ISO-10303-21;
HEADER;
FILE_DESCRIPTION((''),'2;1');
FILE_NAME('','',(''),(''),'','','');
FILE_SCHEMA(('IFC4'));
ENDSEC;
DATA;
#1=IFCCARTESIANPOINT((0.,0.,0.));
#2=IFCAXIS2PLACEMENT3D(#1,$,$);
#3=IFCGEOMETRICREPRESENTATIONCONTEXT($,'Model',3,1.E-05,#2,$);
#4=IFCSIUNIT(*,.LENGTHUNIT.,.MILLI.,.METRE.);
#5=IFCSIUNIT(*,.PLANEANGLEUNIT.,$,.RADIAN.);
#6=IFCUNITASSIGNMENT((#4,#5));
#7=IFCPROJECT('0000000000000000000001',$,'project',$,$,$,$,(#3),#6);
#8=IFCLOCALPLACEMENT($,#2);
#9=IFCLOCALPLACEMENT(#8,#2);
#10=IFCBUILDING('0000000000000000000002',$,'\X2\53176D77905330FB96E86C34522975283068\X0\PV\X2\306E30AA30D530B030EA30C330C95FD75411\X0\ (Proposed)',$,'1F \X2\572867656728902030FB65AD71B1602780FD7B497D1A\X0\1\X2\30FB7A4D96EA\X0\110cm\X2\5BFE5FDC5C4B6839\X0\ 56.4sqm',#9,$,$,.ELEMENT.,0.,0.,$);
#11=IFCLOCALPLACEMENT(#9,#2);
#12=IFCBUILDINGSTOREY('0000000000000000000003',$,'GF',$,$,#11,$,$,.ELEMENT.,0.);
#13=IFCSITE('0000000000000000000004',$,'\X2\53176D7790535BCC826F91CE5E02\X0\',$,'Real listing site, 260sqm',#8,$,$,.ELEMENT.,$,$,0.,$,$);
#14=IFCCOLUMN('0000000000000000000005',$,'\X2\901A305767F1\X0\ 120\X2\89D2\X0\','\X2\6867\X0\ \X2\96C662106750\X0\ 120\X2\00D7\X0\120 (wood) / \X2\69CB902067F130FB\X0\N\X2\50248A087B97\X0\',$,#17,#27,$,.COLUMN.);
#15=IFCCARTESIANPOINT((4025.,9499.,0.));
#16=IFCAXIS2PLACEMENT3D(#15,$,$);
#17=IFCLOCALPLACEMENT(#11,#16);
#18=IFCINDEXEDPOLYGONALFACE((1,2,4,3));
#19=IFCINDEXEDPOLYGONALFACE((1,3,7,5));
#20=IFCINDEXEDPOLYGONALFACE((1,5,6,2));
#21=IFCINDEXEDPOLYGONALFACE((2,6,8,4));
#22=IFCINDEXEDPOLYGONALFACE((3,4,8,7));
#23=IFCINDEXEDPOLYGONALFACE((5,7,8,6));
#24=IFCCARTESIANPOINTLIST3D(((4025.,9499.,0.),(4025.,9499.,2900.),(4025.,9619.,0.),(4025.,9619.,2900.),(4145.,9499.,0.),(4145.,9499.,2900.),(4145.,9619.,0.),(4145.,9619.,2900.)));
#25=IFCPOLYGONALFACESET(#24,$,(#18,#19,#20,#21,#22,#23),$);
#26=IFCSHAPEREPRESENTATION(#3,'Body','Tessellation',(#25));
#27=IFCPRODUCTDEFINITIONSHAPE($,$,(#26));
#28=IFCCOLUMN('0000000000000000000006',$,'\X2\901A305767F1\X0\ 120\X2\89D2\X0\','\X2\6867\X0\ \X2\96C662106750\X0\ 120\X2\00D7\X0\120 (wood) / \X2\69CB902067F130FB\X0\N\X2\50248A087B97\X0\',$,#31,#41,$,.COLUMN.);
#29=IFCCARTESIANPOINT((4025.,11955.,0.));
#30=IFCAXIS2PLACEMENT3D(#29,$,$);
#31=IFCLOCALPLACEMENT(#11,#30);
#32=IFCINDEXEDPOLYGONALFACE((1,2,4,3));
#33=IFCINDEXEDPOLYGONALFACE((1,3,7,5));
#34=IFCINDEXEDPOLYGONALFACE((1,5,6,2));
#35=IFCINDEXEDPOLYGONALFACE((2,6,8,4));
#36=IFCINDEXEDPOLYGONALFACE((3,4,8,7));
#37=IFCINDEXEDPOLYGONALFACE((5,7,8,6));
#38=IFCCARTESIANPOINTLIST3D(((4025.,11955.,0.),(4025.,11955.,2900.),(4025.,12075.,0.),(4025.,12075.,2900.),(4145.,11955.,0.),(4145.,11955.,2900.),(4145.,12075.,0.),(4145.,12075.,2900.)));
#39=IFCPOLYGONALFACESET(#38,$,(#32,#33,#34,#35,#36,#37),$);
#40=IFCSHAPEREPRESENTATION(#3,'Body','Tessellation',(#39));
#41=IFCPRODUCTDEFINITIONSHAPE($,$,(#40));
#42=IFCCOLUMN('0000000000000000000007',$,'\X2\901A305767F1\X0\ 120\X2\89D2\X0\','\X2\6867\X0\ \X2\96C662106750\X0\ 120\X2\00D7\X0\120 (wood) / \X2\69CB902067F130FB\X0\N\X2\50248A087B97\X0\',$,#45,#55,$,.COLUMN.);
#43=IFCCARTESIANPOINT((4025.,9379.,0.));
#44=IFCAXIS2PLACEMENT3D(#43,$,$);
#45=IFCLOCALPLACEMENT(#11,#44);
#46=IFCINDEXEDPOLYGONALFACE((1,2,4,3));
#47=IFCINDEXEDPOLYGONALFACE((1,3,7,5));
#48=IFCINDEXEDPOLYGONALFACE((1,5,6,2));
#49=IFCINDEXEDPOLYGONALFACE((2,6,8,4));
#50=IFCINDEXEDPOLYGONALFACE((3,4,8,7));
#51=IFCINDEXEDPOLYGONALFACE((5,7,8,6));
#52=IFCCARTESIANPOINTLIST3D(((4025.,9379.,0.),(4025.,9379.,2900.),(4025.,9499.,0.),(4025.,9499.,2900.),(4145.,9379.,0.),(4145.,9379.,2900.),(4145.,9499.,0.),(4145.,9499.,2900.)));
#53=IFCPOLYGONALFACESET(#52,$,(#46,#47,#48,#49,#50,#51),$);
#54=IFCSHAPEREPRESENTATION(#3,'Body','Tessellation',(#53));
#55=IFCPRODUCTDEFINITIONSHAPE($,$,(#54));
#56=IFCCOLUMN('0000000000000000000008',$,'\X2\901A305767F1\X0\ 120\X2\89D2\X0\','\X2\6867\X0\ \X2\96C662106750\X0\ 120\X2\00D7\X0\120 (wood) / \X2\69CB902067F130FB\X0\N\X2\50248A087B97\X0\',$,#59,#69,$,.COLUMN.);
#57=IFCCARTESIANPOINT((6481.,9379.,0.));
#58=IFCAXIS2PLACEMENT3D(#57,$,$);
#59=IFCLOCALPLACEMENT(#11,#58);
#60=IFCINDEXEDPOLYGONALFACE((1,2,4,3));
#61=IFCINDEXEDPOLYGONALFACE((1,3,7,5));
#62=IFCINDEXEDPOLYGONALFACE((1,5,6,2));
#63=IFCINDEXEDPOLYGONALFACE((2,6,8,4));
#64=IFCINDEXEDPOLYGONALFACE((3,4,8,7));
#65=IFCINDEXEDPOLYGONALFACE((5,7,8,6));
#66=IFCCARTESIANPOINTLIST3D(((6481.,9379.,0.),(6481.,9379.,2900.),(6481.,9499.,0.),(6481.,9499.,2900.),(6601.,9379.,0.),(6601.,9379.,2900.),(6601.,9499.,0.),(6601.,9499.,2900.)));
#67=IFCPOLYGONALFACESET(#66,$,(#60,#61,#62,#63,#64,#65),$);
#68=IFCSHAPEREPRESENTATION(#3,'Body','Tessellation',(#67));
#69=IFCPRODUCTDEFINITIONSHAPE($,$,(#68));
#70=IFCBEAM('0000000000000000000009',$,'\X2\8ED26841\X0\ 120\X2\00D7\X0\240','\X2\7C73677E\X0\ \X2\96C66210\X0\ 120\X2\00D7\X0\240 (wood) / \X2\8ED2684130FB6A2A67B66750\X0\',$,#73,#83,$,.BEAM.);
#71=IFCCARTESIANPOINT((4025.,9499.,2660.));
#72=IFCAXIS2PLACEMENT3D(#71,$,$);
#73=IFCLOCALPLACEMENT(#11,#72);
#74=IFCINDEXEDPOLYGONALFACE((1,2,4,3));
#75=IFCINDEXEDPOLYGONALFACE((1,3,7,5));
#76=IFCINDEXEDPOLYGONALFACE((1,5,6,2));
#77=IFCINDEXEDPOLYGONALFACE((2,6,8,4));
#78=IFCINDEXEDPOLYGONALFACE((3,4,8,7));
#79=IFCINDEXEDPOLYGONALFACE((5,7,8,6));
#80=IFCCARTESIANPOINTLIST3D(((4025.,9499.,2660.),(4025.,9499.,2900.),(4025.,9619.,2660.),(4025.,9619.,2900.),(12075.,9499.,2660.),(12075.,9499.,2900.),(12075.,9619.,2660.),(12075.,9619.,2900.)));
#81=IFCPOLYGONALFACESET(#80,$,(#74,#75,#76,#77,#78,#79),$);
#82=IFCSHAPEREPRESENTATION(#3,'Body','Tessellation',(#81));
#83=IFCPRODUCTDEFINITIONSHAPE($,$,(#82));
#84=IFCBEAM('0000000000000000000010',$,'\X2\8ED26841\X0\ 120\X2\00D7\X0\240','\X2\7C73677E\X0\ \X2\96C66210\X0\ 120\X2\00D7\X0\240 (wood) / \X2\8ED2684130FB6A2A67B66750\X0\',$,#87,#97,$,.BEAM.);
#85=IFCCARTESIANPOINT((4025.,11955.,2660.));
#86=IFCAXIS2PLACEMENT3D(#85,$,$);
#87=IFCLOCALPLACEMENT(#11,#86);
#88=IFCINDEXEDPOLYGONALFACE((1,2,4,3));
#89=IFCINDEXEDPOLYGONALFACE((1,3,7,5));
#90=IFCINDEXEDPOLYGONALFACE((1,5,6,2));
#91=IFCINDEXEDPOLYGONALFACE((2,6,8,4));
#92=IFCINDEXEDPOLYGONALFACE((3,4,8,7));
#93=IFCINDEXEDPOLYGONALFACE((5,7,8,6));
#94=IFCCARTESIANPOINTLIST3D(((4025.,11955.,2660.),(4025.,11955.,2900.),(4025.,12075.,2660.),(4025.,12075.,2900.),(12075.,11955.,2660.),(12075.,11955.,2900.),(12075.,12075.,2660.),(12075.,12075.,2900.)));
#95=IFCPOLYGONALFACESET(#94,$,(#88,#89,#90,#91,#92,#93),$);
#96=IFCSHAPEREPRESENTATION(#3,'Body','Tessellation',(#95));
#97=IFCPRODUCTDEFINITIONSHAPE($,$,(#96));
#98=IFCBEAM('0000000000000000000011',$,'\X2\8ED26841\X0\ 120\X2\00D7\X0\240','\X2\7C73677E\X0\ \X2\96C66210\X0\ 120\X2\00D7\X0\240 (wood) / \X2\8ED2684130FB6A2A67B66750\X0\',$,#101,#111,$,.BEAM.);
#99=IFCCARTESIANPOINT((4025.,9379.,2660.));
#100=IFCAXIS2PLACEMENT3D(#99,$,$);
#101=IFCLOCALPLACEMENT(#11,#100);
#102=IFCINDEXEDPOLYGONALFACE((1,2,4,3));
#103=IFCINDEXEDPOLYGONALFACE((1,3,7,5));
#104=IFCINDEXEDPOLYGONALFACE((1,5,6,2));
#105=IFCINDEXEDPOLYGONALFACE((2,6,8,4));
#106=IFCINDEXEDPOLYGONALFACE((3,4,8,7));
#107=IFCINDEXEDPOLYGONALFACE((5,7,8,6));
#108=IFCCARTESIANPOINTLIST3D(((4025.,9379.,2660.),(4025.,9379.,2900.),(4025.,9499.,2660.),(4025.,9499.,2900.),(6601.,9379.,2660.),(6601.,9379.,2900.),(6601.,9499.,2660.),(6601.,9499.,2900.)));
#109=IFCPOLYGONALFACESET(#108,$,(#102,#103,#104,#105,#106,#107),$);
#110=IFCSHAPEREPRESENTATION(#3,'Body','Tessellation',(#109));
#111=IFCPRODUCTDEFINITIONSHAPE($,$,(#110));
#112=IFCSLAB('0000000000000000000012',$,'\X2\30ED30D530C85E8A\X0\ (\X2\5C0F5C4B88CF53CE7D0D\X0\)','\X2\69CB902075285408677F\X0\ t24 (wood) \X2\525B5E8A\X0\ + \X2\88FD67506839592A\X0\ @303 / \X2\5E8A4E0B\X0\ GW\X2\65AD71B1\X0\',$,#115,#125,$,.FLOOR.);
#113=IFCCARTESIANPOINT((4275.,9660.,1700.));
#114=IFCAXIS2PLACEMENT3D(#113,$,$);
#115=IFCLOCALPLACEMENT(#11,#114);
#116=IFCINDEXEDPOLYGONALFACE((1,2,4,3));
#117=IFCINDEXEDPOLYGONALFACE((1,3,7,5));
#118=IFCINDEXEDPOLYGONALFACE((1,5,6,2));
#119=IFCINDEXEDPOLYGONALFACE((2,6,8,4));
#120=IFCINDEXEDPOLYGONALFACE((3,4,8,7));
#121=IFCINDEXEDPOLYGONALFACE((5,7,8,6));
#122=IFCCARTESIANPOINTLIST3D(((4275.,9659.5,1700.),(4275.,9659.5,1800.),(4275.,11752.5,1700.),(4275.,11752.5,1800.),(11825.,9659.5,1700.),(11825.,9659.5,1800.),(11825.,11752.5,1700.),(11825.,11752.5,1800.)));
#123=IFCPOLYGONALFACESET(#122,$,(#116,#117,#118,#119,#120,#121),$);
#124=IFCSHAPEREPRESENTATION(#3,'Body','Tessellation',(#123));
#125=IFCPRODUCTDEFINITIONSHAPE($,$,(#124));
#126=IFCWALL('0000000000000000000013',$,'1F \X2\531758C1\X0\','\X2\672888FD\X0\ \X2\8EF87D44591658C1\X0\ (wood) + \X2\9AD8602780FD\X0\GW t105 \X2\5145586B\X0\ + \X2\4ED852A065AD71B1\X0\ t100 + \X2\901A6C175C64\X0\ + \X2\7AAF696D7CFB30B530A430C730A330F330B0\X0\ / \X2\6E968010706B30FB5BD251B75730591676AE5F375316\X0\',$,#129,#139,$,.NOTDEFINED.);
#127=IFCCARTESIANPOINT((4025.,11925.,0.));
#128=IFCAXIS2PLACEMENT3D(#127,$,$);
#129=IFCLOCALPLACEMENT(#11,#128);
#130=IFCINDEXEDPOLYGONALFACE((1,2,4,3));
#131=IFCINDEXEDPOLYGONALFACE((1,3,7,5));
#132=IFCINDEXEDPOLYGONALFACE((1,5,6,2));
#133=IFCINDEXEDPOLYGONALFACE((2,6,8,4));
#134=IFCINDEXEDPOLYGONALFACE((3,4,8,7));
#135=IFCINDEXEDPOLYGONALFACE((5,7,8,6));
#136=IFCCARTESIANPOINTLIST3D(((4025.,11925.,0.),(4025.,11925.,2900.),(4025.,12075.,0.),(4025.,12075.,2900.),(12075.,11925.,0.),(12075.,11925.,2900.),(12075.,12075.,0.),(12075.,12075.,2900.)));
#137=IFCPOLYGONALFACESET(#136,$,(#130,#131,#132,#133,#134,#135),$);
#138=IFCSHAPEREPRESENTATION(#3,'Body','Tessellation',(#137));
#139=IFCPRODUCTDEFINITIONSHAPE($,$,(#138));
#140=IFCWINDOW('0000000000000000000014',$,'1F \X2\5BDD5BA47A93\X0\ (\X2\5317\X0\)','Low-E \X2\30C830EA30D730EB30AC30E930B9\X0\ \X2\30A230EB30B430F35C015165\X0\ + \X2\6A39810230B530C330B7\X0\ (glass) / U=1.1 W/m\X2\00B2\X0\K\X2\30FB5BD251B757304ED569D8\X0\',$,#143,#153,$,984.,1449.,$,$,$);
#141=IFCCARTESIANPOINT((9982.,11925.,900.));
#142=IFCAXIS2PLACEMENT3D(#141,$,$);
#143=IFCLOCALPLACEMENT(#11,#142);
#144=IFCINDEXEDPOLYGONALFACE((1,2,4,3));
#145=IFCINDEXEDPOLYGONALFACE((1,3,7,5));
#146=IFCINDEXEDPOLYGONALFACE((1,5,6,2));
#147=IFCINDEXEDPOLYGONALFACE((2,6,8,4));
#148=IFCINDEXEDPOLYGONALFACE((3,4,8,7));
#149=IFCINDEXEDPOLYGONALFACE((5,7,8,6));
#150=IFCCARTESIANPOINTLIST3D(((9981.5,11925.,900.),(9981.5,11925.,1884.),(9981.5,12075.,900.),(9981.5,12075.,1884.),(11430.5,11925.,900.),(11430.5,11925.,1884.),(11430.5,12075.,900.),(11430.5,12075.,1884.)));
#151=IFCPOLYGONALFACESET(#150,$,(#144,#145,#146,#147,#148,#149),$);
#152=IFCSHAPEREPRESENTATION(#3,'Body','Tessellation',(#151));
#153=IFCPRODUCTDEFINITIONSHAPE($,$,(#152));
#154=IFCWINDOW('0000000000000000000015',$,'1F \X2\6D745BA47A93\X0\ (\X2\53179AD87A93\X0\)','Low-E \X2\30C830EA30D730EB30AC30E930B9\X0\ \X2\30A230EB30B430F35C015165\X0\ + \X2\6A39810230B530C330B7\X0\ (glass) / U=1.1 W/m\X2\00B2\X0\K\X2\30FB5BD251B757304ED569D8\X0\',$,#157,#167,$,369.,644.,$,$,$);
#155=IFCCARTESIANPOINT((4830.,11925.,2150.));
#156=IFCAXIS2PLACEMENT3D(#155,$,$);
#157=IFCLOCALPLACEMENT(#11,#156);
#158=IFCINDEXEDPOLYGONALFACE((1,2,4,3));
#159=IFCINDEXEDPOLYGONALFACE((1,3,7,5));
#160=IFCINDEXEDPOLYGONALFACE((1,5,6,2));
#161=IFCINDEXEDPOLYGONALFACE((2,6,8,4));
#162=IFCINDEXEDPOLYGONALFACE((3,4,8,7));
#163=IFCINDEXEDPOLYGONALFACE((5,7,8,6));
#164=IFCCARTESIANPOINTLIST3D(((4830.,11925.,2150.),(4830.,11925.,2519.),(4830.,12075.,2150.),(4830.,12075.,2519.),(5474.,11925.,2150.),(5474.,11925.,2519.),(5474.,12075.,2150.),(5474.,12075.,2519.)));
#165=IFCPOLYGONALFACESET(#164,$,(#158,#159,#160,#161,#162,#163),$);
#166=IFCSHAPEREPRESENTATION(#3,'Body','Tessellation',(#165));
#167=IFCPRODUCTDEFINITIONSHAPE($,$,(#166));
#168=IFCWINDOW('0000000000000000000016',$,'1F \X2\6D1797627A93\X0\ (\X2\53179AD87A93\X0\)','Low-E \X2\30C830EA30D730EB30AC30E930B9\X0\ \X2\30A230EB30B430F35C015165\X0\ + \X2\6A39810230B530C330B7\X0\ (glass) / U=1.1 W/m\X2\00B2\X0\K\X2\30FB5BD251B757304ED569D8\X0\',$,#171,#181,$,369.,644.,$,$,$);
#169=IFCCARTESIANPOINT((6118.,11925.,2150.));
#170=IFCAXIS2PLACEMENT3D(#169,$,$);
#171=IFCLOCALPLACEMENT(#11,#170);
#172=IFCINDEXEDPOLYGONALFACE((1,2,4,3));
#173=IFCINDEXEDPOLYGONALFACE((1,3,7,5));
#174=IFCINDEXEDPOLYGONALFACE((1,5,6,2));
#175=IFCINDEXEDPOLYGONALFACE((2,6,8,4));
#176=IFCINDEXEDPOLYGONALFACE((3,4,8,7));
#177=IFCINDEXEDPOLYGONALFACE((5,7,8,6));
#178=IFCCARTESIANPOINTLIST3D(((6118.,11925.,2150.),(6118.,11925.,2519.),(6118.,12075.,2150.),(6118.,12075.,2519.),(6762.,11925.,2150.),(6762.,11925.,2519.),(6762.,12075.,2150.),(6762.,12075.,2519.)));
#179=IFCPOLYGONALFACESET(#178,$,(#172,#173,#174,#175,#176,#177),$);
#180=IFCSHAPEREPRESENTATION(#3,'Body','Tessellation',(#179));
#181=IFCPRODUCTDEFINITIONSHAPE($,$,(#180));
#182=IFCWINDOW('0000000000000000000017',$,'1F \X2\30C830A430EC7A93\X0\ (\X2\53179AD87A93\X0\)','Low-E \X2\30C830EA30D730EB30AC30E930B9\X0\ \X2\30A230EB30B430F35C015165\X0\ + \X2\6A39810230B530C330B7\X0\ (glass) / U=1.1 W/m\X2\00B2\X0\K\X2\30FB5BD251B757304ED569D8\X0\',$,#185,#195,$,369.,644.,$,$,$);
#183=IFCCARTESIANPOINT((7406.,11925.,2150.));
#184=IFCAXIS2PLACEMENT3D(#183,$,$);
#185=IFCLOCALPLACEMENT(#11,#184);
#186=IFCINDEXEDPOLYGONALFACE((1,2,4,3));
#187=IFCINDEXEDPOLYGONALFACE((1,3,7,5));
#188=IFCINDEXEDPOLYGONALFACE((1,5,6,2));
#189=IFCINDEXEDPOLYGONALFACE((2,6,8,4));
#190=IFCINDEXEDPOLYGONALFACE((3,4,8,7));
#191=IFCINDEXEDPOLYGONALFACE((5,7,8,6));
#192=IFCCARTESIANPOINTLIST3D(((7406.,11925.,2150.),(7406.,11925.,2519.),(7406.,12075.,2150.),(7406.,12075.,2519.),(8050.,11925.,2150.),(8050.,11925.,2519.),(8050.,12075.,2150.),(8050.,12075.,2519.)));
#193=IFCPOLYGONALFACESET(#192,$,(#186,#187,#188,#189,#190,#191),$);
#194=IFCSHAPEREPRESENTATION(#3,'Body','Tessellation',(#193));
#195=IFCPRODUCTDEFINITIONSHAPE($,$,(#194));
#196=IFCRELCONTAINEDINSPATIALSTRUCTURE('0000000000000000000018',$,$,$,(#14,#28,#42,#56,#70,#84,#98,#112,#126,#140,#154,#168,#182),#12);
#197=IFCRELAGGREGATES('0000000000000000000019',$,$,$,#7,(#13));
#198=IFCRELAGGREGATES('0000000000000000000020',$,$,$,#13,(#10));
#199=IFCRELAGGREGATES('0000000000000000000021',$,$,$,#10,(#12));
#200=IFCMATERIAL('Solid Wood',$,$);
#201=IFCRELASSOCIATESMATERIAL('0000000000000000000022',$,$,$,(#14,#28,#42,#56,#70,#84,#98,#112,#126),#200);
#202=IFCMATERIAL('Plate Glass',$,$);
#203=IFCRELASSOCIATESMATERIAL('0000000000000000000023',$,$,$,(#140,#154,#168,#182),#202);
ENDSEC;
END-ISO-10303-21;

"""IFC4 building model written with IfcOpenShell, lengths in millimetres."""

from ifc_helpers import new_model, si_unit, frame, frame_2d, origin, place, context, project, spatial, rectangle, extrude, material, element, fill, save


model = new_model("IFC4")

# Units and contexts
model_context = context("Model", 3, precision=1e-05, world=origin())
ifc_project = project(units=[si_unit("LENGTHUNIT", "METRE", prefix="MILLI"), si_unit("PLANEANGLEUNIT", "RADIAN")], contexts=[model_context])

# Site, building, storey
site_placement = place(None, origin())
site = spatial("IfcSite", under=ifc_project, at=site_placement, Name="北海道富良野市", ObjectType="Real listing site, 260sqm", CompositionType="ELEMENT", RefElevation=0.0)
building_placement = place(site_placement, origin())
building = spatial("IfcBuilding", under=site, at=building_placement, Name="北海道・雨水利用とPVのオフグリッド志向 (Proposed)", ObjectType="1F 在来木造・断熱性能等級1・積雪110cm対応屋根 56.4sqm", CompositionType="ELEMENT", ElevationOfRefHeight=0.0, ElevationOfTerrain=0.0)
storey_placement = place(building_placement, origin())
storey = spatial("IfcBuildingStorey", under=building, at=storey_placement, Name="GF", CompositionType="ELEMENT", Elevation=0.0)

# Columns
ifc_material_1 = material(Name="Solid Wood")
column_1_placement = place(storey_placement, frame((4025.0, 9499.0, 0.0)))
element("IfcColumn", 1, at=column_1_placement, inside=storey, material=ifc_material_1, Name="通し柱 120角", Description="桧 集成材 120×120 (wood) / 構造柱・N値計算", PredefinedType="COLUMN", context=model_context, shape_type="SweptSolid", body=[
    extrude(rectangle(XDim=120.0, YDim=120.0, at=frame_2d((60.0, 60.0))), frame((4025.0, 9499.0, 0.0)), (0.0, 0.0, 1.0), 2900.0),
])
column_2_placement = place(storey_placement, frame((4025.0, 11955.0, 0.0)))
element("IfcColumn", 2, at=column_2_placement, inside=storey, material=ifc_material_1, Name="通し柱 120角", Description="桧 集成材 120×120 (wood) / 構造柱・N値計算", PredefinedType="COLUMN", context=model_context, shape_type="SweptSolid", body=[
    extrude(rectangle(XDim=120.0, YDim=120.0, at=frame_2d((60.0, 60.0))), frame((4025.0, 11955.0, 0.0)), (0.0, 0.0, 1.0), 2900.0),
])
column_3_placement = place(storey_placement, frame((4025.0, 9379.0, 0.0)))
element("IfcColumn", 3, at=column_3_placement, inside=storey, material=ifc_material_1, Name="通し柱 120角", Description="桧 集成材 120×120 (wood) / 構造柱・N値計算", PredefinedType="COLUMN", context=model_context, shape_type="SweptSolid", body=[
    extrude(rectangle(XDim=120.0, YDim=120.0, at=frame_2d((60.0, 60.0))), frame((4025.0, 9379.0, 0.0)), (0.0, 0.0, 1.0), 2900.0),
])
column_4_placement = place(storey_placement, frame((6481.0, 9379.0, 0.0)))
element("IfcColumn", 4, at=column_4_placement, inside=storey, material=ifc_material_1, Name="通し柱 120角", Description="桧 集成材 120×120 (wood) / 構造柱・N値計算", PredefinedType="COLUMN", context=model_context, shape_type="SweptSolid", body=[
    extrude(rectangle(XDim=120.0, YDim=120.0, at=frame_2d((60.0, 60.0))), frame((6481.0, 9379.0, 0.0)), (0.0, 0.0, 1.0), 2900.0),
])

# Beams
beam_1_placement = place(storey_placement, frame((4025.0, 9499.0, 2660.0)))
element("IfcBeam", 5, at=beam_1_placement, inside=storey, material=ifc_material_1, Name="軒桁 120×240", Description="米松 集成 120×240 (wood) / 軒桁・横架材", PredefinedType="BEAM", context=model_context, shape_type="SweptSolid", body=[
    extrude(rectangle(XDim=8050.0, YDim=120.0, at=frame_2d((4025.0, 60.0))), frame((4025.0, 9499.0, 2660.0)), (0.0, 0.0, 1.0), 240.0),
])
beam_2_placement = place(storey_placement, frame((4025.0, 11955.0, 2660.0)))
element("IfcBeam", 6, at=beam_2_placement, inside=storey, material=ifc_material_1, Name="軒桁 120×240", Description="米松 集成 120×240 (wood) / 軒桁・横架材", PredefinedType="BEAM", context=model_context, shape_type="SweptSolid", body=[
    extrude(rectangle(XDim=8050.0, YDim=120.0, at=frame_2d((4025.0, 60.0))), frame((4025.0, 11955.0, 2660.0)), (0.0, 0.0, 1.0), 240.0),
])
beam_3_placement = place(storey_placement, frame((4025.0, 9379.0, 2660.0)))
element("IfcBeam", 7, at=beam_3_placement, inside=storey, material=ifc_material_1, Name="軒桁 120×240", Description="米松 集成 120×240 (wood) / 軒桁・横架材", PredefinedType="BEAM", context=model_context, shape_type="SweptSolid", body=[
    extrude(rectangle(XDim=2576.0, YDim=120.0, at=frame_2d((1288.0, 60.0))), frame((4025.0, 9379.0, 2660.0)), (0.0, 0.0, 1.0), 240.0),
])

# Slab
slab_1_placement = place(storey_placement, frame((4275.0, 9660.0, 1700.0)))
element("IfcSlab", 8, at=slab_1_placement, inside=storey, material=ifc_material_1, Name="ロフト床 (小屋裏収納)", Description="構造用合板 t24 (wood) 剛床 + 製材根太 @303 / 床下 GW断熱", PredefinedType="FLOOR", context=model_context, shape_type="SweptSolid", body=[
    extrude(rectangle(XDim=7550.0, YDim=2093.0, at=frame_2d((3775.0, 1046.0))), frame((4275.0, 9660.0, 1700.0)), (0.0, 0.0, 1.0), 100.0),
])

# Wall, openings, windows
wall_1_placement = place(storey_placement, frame((4025.0, 11925.0, 0.0)))
wall_1 = element("IfcWall", 9, at=wall_1_placement, inside=storey, material=ifc_material_1, Name="1F 北壁", Description="木製 軸組外壁 (wood) + 高性能GW t105 充填 + 付加断熱 t100 + 通気層 + 窯業系サイディング / 準耐火・寒冷地外皮強化", PredefinedType="NOTDEFINED", context=model_context, shape_type="SweptSolid", body=[
    extrude(rectangle(XDim=8050.0, YDim=150.0, at=frame_2d((4025.0, 75.0))), frame((4025.0, 11925.0, 0.0)), (0.0, 0.0, 1.0), 2900.0),
])
opening_1_placement = place(storey_placement, frame((9982.0, 11925.0, 900.0)))
opening_1 = element("IfcOpeningElement", 10, at=opening_1_placement, cuts=wall_1, PredefinedType="NOTDEFINED", context=model_context, shape_type="SweptSolid", body=[
    extrude(rectangle(XDim=1449.0, YDim=150.0, at=frame_2d((724.0, 75.0))), frame((9982.0, 11925.0, 900.0)), (0.0, 0.0, 1.0), 984.0),
])
opening_2_placement = place(storey_placement, frame((4830.0, 11925.0, 2150.0)))
opening_2 = element("IfcOpeningElement", 11, at=opening_2_placement, cuts=wall_1, PredefinedType="NOTDEFINED", context=model_context, shape_type="SweptSolid", body=[
    extrude(rectangle(XDim=644.0, YDim=150.0, at=frame_2d((322.0, 75.0))), frame((4830.0, 11925.0, 2150.0)), (0.0, 0.0, 1.0), 369.0),
])
opening_3_placement = place(storey_placement, frame((6118.0, 11925.0, 2150.0)))
opening_3 = element("IfcOpeningElement", 12, at=opening_3_placement, cuts=wall_1, PredefinedType="NOTDEFINED", context=model_context, shape_type="SweptSolid", body=[
    extrude(rectangle(XDim=644.0, YDim=150.0, at=frame_2d((322.0, 75.0))), frame((6118.0, 11925.0, 2150.0)), (0.0, 0.0, 1.0), 369.0),
])
opening_4_placement = place(storey_placement, frame((7406.0, 11925.0, 2150.0)))
opening_4 = element("IfcOpeningElement", 13, at=opening_4_placement, cuts=wall_1, PredefinedType="NOTDEFINED", context=model_context, shape_type="SweptSolid", body=[
    extrude(rectangle(XDim=644.0, YDim=150.0, at=frame_2d((322.0, 75.0))), frame((7406.0, 11925.0, 2150.0)), (0.0, 0.0, 1.0), 369.0),
])
ifc_material_2 = material(Name="Plate Glass")
window_1_placement = place(storey_placement, frame((9982.0, 11925.0, 900.0)))
window_1 = element("IfcWindow", 14, at=window_1_placement, inside=storey, material=ifc_material_2, Name="1F 寝室窓 (北)", Description="Low-E トリプルガラス アルゴン封入 + 樹脂サッシ (glass) / U=1.1 W/m²K・寒冷地仕様", OverallHeight=984.0, OverallWidth=1449.0, context=model_context, shape_type="SweptSolid", body=[
    extrude(rectangle(XDim=1449.0, YDim=150.0, at=frame_2d((724.0, 75.0))), frame((9982.0, 11925.0, 900.0)), (0.0, 0.0, 1.0), 984.0),
])
fill(opening_1, window_1)
window_2_placement = place(storey_placement, frame((4830.0, 11925.0, 2150.0)))
window_2 = element("IfcWindow", 15, at=window_2_placement, inside=storey, material=ifc_material_2, Name="1F 浴室窓 (北高窓)", Description="Low-E トリプルガラス アルゴン封入 + 樹脂サッシ (glass) / U=1.1 W/m²K・寒冷地仕様", OverallHeight=369.0, OverallWidth=644.0, context=model_context, shape_type="SweptSolid", body=[
    extrude(rectangle(XDim=644.0, YDim=150.0, at=frame_2d((322.0, 75.0))), frame((4830.0, 11925.0, 2150.0)), (0.0, 0.0, 1.0), 369.0),
])
fill(opening_2, window_2)
window_3_placement = place(storey_placement, frame((6118.0, 11925.0, 2150.0)))
window_3 = element("IfcWindow", 16, at=window_3_placement, inside=storey, material=ifc_material_2, Name="1F 洗面窓 (北高窓)", Description="Low-E トリプルガラス アルゴン封入 + 樹脂サッシ (glass) / U=1.1 W/m²K・寒冷地仕様", OverallHeight=369.0, OverallWidth=644.0, context=model_context, shape_type="SweptSolid", body=[
    extrude(rectangle(XDim=644.0, YDim=150.0, at=frame_2d((322.0, 75.0))), frame((6118.0, 11925.0, 2150.0)), (0.0, 0.0, 1.0), 369.0),
])
fill(opening_3, window_3)
window_4_placement = place(storey_placement, frame((7406.0, 11925.0, 2150.0)))
window_4 = element("IfcWindow", 17, at=window_4_placement, inside=storey, material=ifc_material_2, Name="1F トイレ窓 (北高窓)", Description="Low-E トリプルガラス アルゴン封入 + 樹脂サッシ (glass) / U=1.1 W/m²K・寒冷地仕様", OverallHeight=369.0, OverallWidth=644.0, context=model_context, shape_type="SweptSolid", body=[
    extrude(rectangle(XDim=644.0, YDim=150.0, at=frame_2d((322.0, 75.0))), frame((7406.0, 11925.0, 2150.0)), (0.0, 0.0, 1.0), 369.0),
])
fill(opening_4, window_4)

save(model, "model.ifc")
